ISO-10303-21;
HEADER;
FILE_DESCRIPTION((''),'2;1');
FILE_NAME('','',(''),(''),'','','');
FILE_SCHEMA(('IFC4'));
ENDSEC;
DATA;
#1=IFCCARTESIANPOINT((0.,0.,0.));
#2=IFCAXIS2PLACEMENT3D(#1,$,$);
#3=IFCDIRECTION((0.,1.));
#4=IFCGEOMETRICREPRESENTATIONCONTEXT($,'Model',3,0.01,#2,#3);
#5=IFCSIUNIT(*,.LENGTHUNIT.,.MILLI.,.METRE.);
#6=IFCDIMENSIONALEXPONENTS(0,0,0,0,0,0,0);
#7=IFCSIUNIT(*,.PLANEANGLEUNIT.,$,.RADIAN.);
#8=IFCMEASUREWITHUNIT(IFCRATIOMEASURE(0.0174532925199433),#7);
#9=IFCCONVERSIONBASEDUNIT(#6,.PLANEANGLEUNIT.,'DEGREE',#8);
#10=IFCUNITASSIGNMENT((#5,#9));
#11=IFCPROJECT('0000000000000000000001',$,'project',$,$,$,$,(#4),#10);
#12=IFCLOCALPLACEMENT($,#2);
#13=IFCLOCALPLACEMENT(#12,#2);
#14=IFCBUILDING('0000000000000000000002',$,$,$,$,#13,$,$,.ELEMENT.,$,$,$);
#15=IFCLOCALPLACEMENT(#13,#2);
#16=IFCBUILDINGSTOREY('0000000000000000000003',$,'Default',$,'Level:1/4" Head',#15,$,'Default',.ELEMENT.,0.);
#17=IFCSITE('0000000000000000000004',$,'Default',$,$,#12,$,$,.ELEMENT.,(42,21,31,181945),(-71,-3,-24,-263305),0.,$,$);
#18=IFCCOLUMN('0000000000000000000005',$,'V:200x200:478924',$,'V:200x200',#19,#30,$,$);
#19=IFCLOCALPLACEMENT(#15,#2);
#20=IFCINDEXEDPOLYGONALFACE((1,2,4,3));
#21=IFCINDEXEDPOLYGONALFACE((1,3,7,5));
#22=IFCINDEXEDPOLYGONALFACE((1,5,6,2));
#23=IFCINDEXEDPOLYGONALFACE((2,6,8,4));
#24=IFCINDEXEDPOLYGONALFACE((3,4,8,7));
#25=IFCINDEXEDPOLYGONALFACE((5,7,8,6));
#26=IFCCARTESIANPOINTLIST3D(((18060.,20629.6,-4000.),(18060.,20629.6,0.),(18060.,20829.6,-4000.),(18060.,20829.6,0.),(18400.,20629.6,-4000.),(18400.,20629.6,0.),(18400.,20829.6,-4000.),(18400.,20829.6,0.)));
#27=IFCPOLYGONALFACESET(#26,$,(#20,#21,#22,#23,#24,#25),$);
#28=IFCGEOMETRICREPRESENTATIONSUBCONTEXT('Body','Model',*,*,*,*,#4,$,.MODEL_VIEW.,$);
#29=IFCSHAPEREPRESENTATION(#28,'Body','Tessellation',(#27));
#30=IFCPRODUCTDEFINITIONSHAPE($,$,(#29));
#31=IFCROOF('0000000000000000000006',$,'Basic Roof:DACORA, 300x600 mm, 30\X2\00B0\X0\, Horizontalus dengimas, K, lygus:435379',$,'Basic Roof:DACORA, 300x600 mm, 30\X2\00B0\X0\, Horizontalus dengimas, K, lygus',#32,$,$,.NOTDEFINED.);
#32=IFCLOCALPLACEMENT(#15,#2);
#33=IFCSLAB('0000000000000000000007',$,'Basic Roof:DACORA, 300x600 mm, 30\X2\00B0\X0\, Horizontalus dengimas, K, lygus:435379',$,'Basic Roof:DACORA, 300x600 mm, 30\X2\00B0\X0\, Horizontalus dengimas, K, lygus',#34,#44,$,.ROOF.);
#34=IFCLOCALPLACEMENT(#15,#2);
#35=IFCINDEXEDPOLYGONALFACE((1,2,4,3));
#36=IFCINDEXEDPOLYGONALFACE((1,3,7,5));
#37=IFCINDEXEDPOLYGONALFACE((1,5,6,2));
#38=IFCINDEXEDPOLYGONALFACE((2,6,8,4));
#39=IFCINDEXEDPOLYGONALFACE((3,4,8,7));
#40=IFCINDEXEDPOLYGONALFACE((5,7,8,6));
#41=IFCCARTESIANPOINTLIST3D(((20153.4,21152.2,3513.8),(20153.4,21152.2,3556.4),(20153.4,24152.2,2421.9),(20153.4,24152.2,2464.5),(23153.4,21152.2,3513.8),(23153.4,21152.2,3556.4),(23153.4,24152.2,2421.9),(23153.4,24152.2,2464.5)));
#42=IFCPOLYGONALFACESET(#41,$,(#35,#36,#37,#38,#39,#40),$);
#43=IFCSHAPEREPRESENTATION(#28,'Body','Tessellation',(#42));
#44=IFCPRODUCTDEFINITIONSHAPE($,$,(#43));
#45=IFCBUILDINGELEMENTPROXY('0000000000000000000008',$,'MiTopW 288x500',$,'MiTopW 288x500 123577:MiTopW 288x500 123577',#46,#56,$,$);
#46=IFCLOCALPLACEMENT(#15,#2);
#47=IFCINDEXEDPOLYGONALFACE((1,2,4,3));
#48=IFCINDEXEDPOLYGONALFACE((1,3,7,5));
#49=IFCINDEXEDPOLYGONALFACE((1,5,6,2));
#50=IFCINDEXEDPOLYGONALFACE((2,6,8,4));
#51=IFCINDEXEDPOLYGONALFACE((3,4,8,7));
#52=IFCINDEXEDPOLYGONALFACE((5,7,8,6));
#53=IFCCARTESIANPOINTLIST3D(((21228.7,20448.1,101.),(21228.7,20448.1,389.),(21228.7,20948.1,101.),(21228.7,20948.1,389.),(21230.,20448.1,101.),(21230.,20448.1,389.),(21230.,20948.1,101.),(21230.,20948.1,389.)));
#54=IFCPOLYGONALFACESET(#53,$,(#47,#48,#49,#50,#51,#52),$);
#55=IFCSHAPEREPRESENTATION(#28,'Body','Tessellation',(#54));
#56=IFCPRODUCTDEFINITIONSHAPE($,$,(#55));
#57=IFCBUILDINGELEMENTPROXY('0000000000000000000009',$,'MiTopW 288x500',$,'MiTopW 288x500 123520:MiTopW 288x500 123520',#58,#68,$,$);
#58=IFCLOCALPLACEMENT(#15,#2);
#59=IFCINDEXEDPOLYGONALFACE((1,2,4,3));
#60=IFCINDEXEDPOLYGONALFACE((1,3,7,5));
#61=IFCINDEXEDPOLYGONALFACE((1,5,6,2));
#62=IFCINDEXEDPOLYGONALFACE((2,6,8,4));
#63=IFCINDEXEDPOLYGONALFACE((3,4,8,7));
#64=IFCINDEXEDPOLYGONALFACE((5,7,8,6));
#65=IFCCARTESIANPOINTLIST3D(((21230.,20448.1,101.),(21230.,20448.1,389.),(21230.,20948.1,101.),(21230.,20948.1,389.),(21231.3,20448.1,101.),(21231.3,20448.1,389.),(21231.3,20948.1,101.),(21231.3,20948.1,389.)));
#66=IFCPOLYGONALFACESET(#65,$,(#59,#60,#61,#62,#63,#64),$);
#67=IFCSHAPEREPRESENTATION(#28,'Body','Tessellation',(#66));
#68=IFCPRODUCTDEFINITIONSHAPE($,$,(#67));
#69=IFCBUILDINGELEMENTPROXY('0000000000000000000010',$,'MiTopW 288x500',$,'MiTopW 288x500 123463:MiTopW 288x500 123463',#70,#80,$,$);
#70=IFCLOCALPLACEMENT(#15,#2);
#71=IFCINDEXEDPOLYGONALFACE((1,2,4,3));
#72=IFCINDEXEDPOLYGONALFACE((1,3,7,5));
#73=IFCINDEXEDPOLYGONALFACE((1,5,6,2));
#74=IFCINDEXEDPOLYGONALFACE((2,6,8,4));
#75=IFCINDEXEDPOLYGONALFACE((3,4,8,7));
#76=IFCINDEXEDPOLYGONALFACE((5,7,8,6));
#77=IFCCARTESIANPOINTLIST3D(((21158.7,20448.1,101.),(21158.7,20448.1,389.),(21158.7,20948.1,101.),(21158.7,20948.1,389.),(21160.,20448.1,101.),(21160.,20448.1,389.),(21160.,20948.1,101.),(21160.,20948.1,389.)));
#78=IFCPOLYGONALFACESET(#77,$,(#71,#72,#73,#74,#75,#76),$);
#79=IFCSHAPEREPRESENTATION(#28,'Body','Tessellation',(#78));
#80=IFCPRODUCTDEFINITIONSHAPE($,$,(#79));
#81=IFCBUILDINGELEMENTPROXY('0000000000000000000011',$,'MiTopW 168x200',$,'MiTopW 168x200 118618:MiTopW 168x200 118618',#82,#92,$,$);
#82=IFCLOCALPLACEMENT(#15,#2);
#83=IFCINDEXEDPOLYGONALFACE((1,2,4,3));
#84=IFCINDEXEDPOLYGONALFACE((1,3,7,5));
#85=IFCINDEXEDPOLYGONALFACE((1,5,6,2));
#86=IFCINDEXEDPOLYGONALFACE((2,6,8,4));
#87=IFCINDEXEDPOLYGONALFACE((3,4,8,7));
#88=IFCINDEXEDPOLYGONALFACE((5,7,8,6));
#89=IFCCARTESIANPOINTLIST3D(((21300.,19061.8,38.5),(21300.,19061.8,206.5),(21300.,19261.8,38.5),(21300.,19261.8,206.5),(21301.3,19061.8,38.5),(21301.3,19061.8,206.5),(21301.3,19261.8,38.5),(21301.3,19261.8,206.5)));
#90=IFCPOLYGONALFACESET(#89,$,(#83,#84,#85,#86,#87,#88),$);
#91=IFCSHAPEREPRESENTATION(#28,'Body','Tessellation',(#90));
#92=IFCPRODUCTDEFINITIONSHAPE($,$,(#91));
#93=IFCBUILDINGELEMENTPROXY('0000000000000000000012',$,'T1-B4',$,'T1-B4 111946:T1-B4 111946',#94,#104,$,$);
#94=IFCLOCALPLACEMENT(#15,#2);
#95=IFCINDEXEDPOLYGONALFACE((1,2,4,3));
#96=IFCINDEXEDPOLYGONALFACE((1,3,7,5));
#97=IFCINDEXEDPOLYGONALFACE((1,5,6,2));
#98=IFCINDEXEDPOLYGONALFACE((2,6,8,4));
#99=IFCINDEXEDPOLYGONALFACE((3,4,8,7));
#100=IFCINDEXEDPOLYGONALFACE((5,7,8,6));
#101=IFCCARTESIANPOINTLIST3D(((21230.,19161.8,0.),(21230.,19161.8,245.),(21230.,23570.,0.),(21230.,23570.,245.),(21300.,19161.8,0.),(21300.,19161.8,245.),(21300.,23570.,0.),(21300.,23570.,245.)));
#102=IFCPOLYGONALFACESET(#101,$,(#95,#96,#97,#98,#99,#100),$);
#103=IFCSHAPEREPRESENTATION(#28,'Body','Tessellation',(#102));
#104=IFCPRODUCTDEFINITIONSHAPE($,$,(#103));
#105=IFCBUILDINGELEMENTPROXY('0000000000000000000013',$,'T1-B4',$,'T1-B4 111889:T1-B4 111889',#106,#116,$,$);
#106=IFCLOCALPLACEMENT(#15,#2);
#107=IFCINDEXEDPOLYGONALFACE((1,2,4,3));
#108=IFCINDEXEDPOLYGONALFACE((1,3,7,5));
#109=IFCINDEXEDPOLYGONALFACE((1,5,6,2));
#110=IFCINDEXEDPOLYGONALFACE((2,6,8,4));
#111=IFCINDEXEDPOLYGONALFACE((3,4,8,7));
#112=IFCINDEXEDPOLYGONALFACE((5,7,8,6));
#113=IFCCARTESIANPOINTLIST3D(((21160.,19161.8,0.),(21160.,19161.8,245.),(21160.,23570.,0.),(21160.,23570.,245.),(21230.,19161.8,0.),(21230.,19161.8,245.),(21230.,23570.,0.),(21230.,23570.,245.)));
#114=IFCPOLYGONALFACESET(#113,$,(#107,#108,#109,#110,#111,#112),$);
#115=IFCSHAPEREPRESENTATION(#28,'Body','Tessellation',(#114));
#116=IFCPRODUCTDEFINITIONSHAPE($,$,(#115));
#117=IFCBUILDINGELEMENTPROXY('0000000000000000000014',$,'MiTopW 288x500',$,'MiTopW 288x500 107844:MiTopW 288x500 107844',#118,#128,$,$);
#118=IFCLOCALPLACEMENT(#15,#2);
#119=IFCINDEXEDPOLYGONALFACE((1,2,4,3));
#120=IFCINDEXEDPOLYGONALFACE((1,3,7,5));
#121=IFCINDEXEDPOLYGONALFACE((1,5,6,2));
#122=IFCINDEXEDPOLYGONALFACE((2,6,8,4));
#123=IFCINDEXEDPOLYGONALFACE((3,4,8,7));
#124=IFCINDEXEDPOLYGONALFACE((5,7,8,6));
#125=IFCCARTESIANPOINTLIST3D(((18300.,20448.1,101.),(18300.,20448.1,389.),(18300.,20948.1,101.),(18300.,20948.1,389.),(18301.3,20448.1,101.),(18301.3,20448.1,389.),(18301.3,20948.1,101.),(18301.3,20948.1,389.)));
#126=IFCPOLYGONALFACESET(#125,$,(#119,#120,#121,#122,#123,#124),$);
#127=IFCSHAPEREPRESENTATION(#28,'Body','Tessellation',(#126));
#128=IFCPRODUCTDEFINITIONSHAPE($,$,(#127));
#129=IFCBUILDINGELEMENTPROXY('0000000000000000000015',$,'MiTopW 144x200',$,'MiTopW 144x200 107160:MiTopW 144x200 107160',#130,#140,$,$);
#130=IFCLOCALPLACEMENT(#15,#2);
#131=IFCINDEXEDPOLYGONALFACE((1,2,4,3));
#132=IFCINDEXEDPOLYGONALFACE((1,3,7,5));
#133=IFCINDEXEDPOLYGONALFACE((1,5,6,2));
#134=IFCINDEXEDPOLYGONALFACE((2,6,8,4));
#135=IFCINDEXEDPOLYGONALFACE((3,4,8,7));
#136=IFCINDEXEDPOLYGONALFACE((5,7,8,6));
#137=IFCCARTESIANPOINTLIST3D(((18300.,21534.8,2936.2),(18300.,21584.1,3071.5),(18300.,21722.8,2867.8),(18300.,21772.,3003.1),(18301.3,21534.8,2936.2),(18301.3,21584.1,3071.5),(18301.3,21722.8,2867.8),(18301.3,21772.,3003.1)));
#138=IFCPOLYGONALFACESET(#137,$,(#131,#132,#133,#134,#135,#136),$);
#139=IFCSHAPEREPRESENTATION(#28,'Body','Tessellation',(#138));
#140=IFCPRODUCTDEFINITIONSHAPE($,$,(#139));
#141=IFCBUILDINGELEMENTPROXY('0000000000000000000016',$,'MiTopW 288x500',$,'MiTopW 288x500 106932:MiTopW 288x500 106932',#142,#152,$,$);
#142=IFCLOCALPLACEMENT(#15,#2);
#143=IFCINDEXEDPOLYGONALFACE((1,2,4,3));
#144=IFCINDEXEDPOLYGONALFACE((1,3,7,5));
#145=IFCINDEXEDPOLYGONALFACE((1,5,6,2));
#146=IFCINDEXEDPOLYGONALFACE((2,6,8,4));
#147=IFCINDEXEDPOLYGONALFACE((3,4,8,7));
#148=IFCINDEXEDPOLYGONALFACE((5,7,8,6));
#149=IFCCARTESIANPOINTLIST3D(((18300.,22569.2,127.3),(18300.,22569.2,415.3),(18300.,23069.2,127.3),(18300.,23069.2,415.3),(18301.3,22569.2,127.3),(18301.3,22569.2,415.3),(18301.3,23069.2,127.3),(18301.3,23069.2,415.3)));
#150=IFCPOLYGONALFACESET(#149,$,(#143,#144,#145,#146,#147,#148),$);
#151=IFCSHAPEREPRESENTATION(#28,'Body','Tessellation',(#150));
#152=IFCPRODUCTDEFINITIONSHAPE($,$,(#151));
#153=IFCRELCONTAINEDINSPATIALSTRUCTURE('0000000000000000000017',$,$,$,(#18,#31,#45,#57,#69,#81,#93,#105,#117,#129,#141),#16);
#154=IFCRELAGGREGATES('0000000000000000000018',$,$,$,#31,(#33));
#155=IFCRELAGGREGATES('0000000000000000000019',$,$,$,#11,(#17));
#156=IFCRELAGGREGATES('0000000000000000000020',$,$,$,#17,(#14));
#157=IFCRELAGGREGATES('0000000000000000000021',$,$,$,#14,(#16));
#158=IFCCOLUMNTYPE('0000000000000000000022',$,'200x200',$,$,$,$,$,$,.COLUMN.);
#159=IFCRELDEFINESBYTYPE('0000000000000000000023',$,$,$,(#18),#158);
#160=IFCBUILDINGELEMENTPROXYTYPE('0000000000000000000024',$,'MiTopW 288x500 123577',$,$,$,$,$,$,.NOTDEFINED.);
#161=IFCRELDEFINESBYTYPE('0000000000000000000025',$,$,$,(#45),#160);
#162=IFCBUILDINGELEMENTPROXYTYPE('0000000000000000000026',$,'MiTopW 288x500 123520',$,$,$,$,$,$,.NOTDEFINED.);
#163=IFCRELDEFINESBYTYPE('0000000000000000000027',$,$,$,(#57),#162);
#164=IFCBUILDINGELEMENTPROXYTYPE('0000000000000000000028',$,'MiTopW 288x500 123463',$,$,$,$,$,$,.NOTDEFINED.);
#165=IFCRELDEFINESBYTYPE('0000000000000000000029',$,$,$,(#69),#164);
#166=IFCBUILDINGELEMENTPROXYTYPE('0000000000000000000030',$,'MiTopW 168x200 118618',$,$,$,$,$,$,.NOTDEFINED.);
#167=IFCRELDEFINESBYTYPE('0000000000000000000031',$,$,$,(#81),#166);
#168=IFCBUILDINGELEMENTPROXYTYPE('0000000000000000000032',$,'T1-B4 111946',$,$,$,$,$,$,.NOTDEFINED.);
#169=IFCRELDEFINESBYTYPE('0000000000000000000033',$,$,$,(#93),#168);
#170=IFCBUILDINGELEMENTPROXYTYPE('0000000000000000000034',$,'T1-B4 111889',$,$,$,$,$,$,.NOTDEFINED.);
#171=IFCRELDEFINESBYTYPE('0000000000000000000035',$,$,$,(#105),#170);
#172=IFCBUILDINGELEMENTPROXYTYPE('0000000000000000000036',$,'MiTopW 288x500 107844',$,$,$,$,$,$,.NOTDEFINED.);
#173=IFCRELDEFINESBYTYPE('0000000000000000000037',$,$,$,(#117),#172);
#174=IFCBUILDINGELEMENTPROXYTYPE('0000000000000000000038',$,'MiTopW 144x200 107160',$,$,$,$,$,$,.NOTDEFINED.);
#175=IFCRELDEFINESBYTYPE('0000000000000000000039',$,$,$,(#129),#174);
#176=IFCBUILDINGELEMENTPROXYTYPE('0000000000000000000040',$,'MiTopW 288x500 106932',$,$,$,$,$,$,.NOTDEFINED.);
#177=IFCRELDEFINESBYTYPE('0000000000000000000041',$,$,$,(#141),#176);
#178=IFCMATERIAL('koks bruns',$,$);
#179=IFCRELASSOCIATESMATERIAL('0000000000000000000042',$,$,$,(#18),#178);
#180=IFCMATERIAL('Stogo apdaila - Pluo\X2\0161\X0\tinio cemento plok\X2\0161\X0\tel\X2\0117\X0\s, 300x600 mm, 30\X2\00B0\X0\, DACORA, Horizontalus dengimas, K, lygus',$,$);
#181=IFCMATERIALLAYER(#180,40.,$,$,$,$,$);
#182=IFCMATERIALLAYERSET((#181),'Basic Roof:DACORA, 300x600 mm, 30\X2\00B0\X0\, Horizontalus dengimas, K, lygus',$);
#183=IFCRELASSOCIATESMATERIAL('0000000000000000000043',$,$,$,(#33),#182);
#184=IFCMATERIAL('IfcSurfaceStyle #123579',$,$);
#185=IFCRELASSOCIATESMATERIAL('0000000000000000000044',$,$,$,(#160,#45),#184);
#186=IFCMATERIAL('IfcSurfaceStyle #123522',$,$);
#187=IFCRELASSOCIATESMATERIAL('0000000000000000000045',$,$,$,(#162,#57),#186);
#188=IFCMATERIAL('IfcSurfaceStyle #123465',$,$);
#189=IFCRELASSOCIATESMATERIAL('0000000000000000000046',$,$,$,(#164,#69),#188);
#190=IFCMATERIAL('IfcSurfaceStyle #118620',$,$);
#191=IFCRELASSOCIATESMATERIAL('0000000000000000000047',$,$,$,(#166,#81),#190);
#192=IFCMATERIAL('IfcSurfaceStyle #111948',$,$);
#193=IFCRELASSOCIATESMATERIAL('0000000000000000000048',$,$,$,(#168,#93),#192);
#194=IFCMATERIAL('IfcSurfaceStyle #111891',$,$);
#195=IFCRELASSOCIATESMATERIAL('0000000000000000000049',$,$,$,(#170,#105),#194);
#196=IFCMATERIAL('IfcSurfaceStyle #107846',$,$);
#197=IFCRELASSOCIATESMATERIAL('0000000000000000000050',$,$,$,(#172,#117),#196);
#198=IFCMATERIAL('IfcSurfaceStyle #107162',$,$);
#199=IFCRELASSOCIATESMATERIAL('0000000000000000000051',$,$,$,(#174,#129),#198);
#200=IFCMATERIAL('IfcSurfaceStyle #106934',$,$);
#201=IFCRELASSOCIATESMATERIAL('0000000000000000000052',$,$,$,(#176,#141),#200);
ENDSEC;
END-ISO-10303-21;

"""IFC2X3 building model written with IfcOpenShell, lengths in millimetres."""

from ifc_helpers import new_model, entity, si_unit, converted_unit, direction, frame, frame_2d, origin, origin_2d_with_axis, place, context, subcontext, project, spatial, polyline, rectangle, outline, extrude, source, transform, mapped, material, layer, layer_set, type_object, type_shapes, element, aggregate, save


model = new_model("IFC2X3")

# Units and contexts
model_context = context("Model", 3, precision=0.01, world=origin(), true_north=direction((0.0, 1.0)))
body_context = subcontext(model_context, "Body", "Model", "MODEL_VIEW")
ifc_project = project(units=[si_unit("LENGTHUNIT", "METRE", prefix="MILLI"), converted_unit("PLANEANGLEUNIT", "DEGREE", entity("IfcRatioMeasure", 0.0174532925199433), si_unit("PLANEANGLEUNIT", "RADIAN"), dimensions=[0, 0, 0, 0, 0, 0, 0])], contexts=[model_context])

# Site, building, storey
site_placement = place(None, origin())
site = spatial("IfcSite", under=ifc_project, at=site_placement, Name="Default", CompositionType="ELEMENT", RefLatitude=(42, 21, 31, 181945), RefLongitude=(-71, -3, -24, -263305), RefElevation=0.0)
building_placement = place(site_placement, origin())
building = spatial("IfcBuilding", under=site, at=building_placement, CompositionType="ELEMENT")
storey_placement = place(building_placement, origin())
storey = spatial("IfcBuildingStorey", under=building, at=storey_placement, Name="Default", ObjectType="Level:1/4\" Head", LongName="Default", CompositionType="ELEMENT", Elevation=0.0)

# Column
ifc_material_1 = material(Name="koks bruns")
column_type_1 = type_object("IfcColumnType", Name="200x200", PredefinedType="COLUMN")
shared_shape_1 = source(origin(), body_context, "Body", "SweptSolid", [
    extrude(rectangle(XDim=340.0, YDim=200.0, at=origin_2d_with_axis()), frame((100.0, 280.0, -4000.0), z_axis=(0.0, 0.0, 1.0), x_axis=(0.0, -1.0, 0.0)), (0.0, 0.0, 1.0), 4000.0),
])
type_shapes(column_type_1, [shared_shape_1])
column_placement = place(storey_placement, frame((18510.0, 20629.6, 0.0), z_axis=(0.0, 0.0, 1.0), x_axis=(0.0, 1.0, 0.0)))
element("IfcColumn", 1, at=column_placement, inside=storey, type_object=column_type_1, material=ifc_material_1, Name="V:200x200:478924", ObjectType="V:200x200", context=body_context, shape_type="MappedRepresentation", body=[
    mapped(shared_shape_1, transform((0.0, 0.0, 0.0), scale=1.0)),
])

# Roof, slab
roof_placement = place(storey_placement, frame((20153.4, 21152.2, 2421.9)))
roof = element("IfcRoof", 2, at=roof_placement, inside=storey, Name="Basic Roof:DACORA, 300x600 mm, 30°, Horizontalus dengimas, K, lygus:435379", ObjectType="Basic Roof:DACORA, 300x600 mm, 30°, Horizontalus dengimas, K, lygus", ShapeType="NOTDEFINED")
ifc_material_2 = material(Name="Stogo apdaila - Pluoštinio cemento plokštelės, 300x600 mm, 30°, DACORA, Horizontalus dengimas, K, lygus")
ifc_layer = layer(ifc_material_2, 40.0)
ifc_layer_set = layer_set([ifc_layer], Name="Basic Roof:DACORA, 300x600 mm, 30°, Horizontalus dengimas, K, lygus")
slab_placement = place(roof_placement, origin())
slab = element("IfcSlab", 3, at=slab_placement, material=ifc_layer_set, Name="Basic Roof:DACORA, 300x600 mm, 30°, Horizontalus dengimas, K, lygus:435379", ObjectType="Basic Roof:DACORA, 300x600 mm, 30°, Horizontalus dengimas, K, lygus", PredefinedType="ROOF", context=body_context, shape_type="SweptSolid", body=[
    extrude(rectangle(XDim=3192.5, YDim=3000.0, at=frame_2d((0.0, 0.0), x_axis=(0.0, 1.0))), frame((1500.0, 1500.0, 546.0), z_axis=(0.0, 0.34202, 0.939693), x_axis=(1.0, 0.0, 0.0)), (0.0, -0.34202, 0.939693), 42.6),
])
aggregate(roof, [slab])

# Building element proxies
ifc_material_3 = material(Name="IfcSurfaceStyle #123579")
building_element_proxy_type_1 = type_object("IfcBuildingElementProxyType", Name="MiTopW 288x500 123577", PredefinedType="NOTDEFINED", material=ifc_material_3)
shared_shape_2 = source(origin(), body_context, "Body", "SweptSolid", [
    extrude(rectangle(XDim=500.0, YDim=288.0, at=origin_2d_with_axis()), frame((250.0, 144.0, 0.0), z_axis=(0.0, 0.0, 1.0), x_axis=(-1.0, 0.0, 0.0)), (0.0, 0.0, 1.0), 1.3),
])
type_shapes(building_element_proxy_type_1, [shared_shape_2])
proxy_1_placement = place(building_placement, frame((21230.0, 20948.1, 101.0), z_axis=(-1.0, 0.0, 0.0), x_axis=(0.0, -1.0, 0.0)))
element("IfcBuildingElementProxy", 4, at=proxy_1_placement, inside=storey, type_object=building_element_proxy_type_1, material=ifc_material_3, Name="MiTopW 288x500", ObjectType="MiTopW 288x500 123577:MiTopW 288x500 123577", context=body_context, shape_type="MappedRepresentation", body=[
    mapped(shared_shape_2, transform((0.0, 0.0, 0.0), scale=1.0)),
])
ifc_material_4 = material(Name="IfcSurfaceStyle #123522")
building_element_proxy_type_2 = type_object("IfcBuildingElementProxyType", Name="MiTopW 288x500 123520", PredefinedType="NOTDEFINED", material=ifc_material_4)
shared_shape_3 = source(origin(), body_context, "Body", "SweptSolid", [
    extrude(rectangle(XDim=500.0, YDim=288.0, at=origin_2d_with_axis()), frame((250.0, 144.0, 0.0), z_axis=(0.0, 0.0, 1.0), x_axis=(-1.0, 0.0, 0.0)), (0.0, 0.0, 1.0), 1.3),
])
type_shapes(building_element_proxy_type_2, [shared_shape_3])
proxy_2_placement = place(building_placement, frame((21231.3, 20948.1, 101.0), z_axis=(-1.0, 0.0, 0.0), x_axis=(0.0, -1.0, 0.0)))
element("IfcBuildingElementProxy", 5, at=proxy_2_placement, inside=storey, type_object=building_element_proxy_type_2, material=ifc_material_4, Name="MiTopW 288x500", ObjectType="MiTopW 288x500 123520:MiTopW 288x500 123520", context=body_context, shape_type="MappedRepresentation", body=[
    mapped(shared_shape_3, transform((0.0, 0.0, 0.0), scale=1.0)),
])
ifc_material_5 = material(Name="IfcSurfaceStyle #123465")
building_element_proxy_type_3 = type_object("IfcBuildingElementProxyType", Name="MiTopW 288x500 123463", PredefinedType="NOTDEFINED", material=ifc_material_5)
shared_shape_4 = source(origin(), body_context, "Body", "SweptSolid", [
    extrude(rectangle(XDim=500.0, YDim=288.0, at=origin_2d_with_axis()), frame((250.0, 144.0, 0.0), z_axis=(0.0, 0.0, 1.0), x_axis=(-1.0, 0.0, 0.0)), (0.0, 0.0, 1.0), 1.3),
])
type_shapes(building_element_proxy_type_3, [shared_shape_4])
proxy_3_placement = place(building_placement, frame((21160.0, 20948.1, 101.0), z_axis=(-1.0, 0.0, 0.0), x_axis=(0.0, -1.0, 0.0)))
element("IfcBuildingElementProxy", 6, at=proxy_3_placement, inside=storey, type_object=building_element_proxy_type_3, material=ifc_material_5, Name="MiTopW 288x500", ObjectType="MiTopW 288x500 123463:MiTopW 288x500 123463", context=body_context, shape_type="MappedRepresentation", body=[
    mapped(shared_shape_4, transform((0.0, 0.0, 0.0), scale=1.0)),
])
ifc_material_6 = material(Name="IfcSurfaceStyle #118620")
building_element_proxy_type_4 = type_object("IfcBuildingElementProxyType", Name="MiTopW 168x200 118618", PredefinedType="NOTDEFINED", material=ifc_material_6)
shared_shape_5 = source(origin(), body_context, "Body", "SweptSolid", [
    extrude(rectangle(XDim=200.0, YDim=168.0, at=origin_2d_with_axis()), frame((100.0, 84.0, 0.0), z_axis=(0.0, 0.0, 1.0), x_axis=(-1.0, 0.0, 0.0)), (0.0, 0.0, 1.0), 1.3),
])
type_shapes(building_element_proxy_type_4, [shared_shape_5])
proxy_4_placement = place(building_placement, frame((21301.3, 19061.8, 206.5), z_axis=(-1.0, 0.0, 0.0), x_axis=(0.0, 1.0, 0.0)))
element("IfcBuildingElementProxy", 7, at=proxy_4_placement, inside=storey, type_object=building_element_proxy_type_4, material=ifc_material_6, Name="MiTopW 168x200", ObjectType="MiTopW 168x200 118618:MiTopW 168x200 118618", context=body_context, shape_type="MappedRepresentation", body=[
    mapped(shared_shape_5, transform((0.0, 0.0, 0.0), scale=1.0)),
])
ifc_material_7 = material(Name="IfcSurfaceStyle #111948")
building_element_proxy_type_5 = type_object("IfcBuildingElementProxyType", Name="T1-B4 111946", PredefinedType="NOTDEFINED", material=ifc_material_7)
shared_shape_6 = source(origin(), body_context, "Body", "SweptSolid", [
    extrude(rectangle(XDim=4408.2, YDim=245.0, at=origin_2d_with_axis()), frame((2204.1, 122.5, 0.0), z_axis=(0.0, 0.0, 1.0), x_axis=(-1.0, 0.0, 0.0)), (0.0, 0.0, 1.0), 70.0),
])
type_shapes(building_element_proxy_type_5, [shared_shape_6])
proxy_5_placement = place(building_placement, frame((21300.0, 19161.8, 245.0), z_axis=(-1.0, 0.0, 0.0), x_axis=(0.0, 1.0, 0.0)))
element("IfcBuildingElementProxy", 8, at=proxy_5_placement, inside=storey, type_object=building_element_proxy_type_5, material=ifc_material_7, Name="T1-B4", ObjectType="T1-B4 111946:T1-B4 111946", context=body_context, shape_type="MappedRepresentation", body=[
    mapped(shared_shape_6, transform((0.0, 0.0, 0.0), scale=1.0)),
])
ifc_material_8 = material(Name="IfcSurfaceStyle #111891")
building_element_proxy_type_6 = type_object("IfcBuildingElementProxyType", Name="T1-B4 111889", PredefinedType="NOTDEFINED", material=ifc_material_8)
shared_shape_7 = source(origin(), body_context, "Body", "SweptSolid", [
    extrude(rectangle(XDim=4408.2, YDim=245.0, at=origin_2d_with_axis()), frame((2204.1, 122.5, 0.0), z_axis=(0.0, 0.0, 1.0), x_axis=(-1.0, 0.0, 0.0)), (0.0, 0.0, 1.0), 70.0),
])
type_shapes(building_element_proxy_type_6, [shared_shape_7])
proxy_6_placement = place(building_placement, frame((21230.0, 19161.8, 245.0), z_axis=(-1.0, 0.0, 0.0), x_axis=(0.0, 1.0, 0.0)))
element("IfcBuildingElementProxy", 9, at=proxy_6_placement, inside=storey, type_object=building_element_proxy_type_6, material=ifc_material_8, Name="T1-B4", ObjectType="T1-B4 111889:T1-B4 111889", context=body_context, shape_type="MappedRepresentation", body=[
    mapped(shared_shape_7, transform((0.0, 0.0, 0.0), scale=1.0)),
])
ifc_material_9 = material(Name="IfcSurfaceStyle #107846")
building_element_proxy_type_7 = type_object("IfcBuildingElementProxyType", Name="MiTopW 288x500 107844", PredefinedType="NOTDEFINED", material=ifc_material_9)
shared_shape_8 = source(origin(), body_context, "Body", "SweptSolid", [
    extrude(rectangle(XDim=500.0, YDim=288.0, at=origin_2d_with_axis()), frame((250.0, 144.0, 0.0), z_axis=(0.0, 0.0, 1.0), x_axis=(-1.0, 0.0, 0.0)), (0.0, 0.0, 1.0), 1.3),
])
type_shapes(building_element_proxy_type_7, [shared_shape_8])
proxy_7_placement = place(building_placement, frame((18301.3, 20948.1, 101.0), z_axis=(-1.0, 0.0, 0.0), x_axis=(0.0, -1.0, 0.0)))
element("IfcBuildingElementProxy", 10, at=proxy_7_placement, inside=storey, type_object=building_element_proxy_type_7, material=ifc_material_9, Name="MiTopW 288x500", ObjectType="MiTopW 288x500 107844:MiTopW 288x500 107844", context=body_context, shape_type="MappedRepresentation", body=[
    mapped(shared_shape_8, transform((0.0, 0.0, 0.0), scale=1.0)),
])
ifc_material_10 = material(Name="IfcSurfaceStyle #107162")
building_element_proxy_type_8 = type_object("IfcBuildingElementProxyType", Name="MiTopW 144x200 107160", PredefinedType="NOTDEFINED", material=ifc_material_10)
shared_shape_9 = source(origin(), body_context, "Body", "SweptSolid", [
    extrude(outline(polyline([(-100.0, -72.0), (100.0, -72.0), (100.0, 72.0), (-100.0, 72.0), (-100.0, -72.0)])), frame((100.0, 72.0, 0.0), z_axis=(0.0, 0.0, 1.0), x_axis=(-1.0, 0.0, 0.0)), (0.0, 0.0, 1.0), 1.3),
])
type_shapes(building_element_proxy_type_8, [shared_shape_9])
proxy_8_placement = place(building_placement, frame((18301.3, 21584.1, 3071.5), z_axis=(-1.0, 0.0, 0.0), x_axis=(0.0, 0.939693, -0.34202)))
element("IfcBuildingElementProxy", 11, at=proxy_8_placement, inside=storey, type_object=building_element_proxy_type_8, material=ifc_material_10, Name="MiTopW 144x200", ObjectType="MiTopW 144x200 107160:MiTopW 144x200 107160", context=body_context, shape_type="MappedRepresentation", body=[
    mapped(shared_shape_9, transform((0.0, 0.0, 0.0), scale=1.0)),
])
ifc_material_11 = material(Name="IfcSurfaceStyle #106934")
building_element_proxy_type_9 = type_object("IfcBuildingElementProxyType", Name="MiTopW 288x500 106932", PredefinedType="NOTDEFINED", material=ifc_material_11)
shared_shape_10 = source(origin(), body_context, "Body", "SweptSolid", [
    extrude(rectangle(XDim=500.0, YDim=288.0, at=origin_2d_with_axis()), frame((250.0, 144.0, 0.0), z_axis=(0.0, 0.0, 1.0), x_axis=(-1.0, 0.0, 0.0)), (0.0, 0.0, 1.0), 1.3),
])
type_shapes(building_element_proxy_type_9, [shared_shape_10])
proxy_9_placement = place(building_placement, frame((18301.3, 23069.2, 127.3), z_axis=(-1.0, 0.0, 0.0), x_axis=(0.0, -1.0, 0.0)))
element("IfcBuildingElementProxy", 12, at=proxy_9_placement, inside=storey, type_object=building_element_proxy_type_9, material=ifc_material_11, Name="MiTopW 288x500", ObjectType="MiTopW 288x500 106932:MiTopW 288x500 106932", context=body_context, shape_type="MappedRepresentation", body=[
    mapped(shared_shape_10, transform((0.0, 0.0, 0.0), scale=1.0)),
])

save(model, "model.ifc")
